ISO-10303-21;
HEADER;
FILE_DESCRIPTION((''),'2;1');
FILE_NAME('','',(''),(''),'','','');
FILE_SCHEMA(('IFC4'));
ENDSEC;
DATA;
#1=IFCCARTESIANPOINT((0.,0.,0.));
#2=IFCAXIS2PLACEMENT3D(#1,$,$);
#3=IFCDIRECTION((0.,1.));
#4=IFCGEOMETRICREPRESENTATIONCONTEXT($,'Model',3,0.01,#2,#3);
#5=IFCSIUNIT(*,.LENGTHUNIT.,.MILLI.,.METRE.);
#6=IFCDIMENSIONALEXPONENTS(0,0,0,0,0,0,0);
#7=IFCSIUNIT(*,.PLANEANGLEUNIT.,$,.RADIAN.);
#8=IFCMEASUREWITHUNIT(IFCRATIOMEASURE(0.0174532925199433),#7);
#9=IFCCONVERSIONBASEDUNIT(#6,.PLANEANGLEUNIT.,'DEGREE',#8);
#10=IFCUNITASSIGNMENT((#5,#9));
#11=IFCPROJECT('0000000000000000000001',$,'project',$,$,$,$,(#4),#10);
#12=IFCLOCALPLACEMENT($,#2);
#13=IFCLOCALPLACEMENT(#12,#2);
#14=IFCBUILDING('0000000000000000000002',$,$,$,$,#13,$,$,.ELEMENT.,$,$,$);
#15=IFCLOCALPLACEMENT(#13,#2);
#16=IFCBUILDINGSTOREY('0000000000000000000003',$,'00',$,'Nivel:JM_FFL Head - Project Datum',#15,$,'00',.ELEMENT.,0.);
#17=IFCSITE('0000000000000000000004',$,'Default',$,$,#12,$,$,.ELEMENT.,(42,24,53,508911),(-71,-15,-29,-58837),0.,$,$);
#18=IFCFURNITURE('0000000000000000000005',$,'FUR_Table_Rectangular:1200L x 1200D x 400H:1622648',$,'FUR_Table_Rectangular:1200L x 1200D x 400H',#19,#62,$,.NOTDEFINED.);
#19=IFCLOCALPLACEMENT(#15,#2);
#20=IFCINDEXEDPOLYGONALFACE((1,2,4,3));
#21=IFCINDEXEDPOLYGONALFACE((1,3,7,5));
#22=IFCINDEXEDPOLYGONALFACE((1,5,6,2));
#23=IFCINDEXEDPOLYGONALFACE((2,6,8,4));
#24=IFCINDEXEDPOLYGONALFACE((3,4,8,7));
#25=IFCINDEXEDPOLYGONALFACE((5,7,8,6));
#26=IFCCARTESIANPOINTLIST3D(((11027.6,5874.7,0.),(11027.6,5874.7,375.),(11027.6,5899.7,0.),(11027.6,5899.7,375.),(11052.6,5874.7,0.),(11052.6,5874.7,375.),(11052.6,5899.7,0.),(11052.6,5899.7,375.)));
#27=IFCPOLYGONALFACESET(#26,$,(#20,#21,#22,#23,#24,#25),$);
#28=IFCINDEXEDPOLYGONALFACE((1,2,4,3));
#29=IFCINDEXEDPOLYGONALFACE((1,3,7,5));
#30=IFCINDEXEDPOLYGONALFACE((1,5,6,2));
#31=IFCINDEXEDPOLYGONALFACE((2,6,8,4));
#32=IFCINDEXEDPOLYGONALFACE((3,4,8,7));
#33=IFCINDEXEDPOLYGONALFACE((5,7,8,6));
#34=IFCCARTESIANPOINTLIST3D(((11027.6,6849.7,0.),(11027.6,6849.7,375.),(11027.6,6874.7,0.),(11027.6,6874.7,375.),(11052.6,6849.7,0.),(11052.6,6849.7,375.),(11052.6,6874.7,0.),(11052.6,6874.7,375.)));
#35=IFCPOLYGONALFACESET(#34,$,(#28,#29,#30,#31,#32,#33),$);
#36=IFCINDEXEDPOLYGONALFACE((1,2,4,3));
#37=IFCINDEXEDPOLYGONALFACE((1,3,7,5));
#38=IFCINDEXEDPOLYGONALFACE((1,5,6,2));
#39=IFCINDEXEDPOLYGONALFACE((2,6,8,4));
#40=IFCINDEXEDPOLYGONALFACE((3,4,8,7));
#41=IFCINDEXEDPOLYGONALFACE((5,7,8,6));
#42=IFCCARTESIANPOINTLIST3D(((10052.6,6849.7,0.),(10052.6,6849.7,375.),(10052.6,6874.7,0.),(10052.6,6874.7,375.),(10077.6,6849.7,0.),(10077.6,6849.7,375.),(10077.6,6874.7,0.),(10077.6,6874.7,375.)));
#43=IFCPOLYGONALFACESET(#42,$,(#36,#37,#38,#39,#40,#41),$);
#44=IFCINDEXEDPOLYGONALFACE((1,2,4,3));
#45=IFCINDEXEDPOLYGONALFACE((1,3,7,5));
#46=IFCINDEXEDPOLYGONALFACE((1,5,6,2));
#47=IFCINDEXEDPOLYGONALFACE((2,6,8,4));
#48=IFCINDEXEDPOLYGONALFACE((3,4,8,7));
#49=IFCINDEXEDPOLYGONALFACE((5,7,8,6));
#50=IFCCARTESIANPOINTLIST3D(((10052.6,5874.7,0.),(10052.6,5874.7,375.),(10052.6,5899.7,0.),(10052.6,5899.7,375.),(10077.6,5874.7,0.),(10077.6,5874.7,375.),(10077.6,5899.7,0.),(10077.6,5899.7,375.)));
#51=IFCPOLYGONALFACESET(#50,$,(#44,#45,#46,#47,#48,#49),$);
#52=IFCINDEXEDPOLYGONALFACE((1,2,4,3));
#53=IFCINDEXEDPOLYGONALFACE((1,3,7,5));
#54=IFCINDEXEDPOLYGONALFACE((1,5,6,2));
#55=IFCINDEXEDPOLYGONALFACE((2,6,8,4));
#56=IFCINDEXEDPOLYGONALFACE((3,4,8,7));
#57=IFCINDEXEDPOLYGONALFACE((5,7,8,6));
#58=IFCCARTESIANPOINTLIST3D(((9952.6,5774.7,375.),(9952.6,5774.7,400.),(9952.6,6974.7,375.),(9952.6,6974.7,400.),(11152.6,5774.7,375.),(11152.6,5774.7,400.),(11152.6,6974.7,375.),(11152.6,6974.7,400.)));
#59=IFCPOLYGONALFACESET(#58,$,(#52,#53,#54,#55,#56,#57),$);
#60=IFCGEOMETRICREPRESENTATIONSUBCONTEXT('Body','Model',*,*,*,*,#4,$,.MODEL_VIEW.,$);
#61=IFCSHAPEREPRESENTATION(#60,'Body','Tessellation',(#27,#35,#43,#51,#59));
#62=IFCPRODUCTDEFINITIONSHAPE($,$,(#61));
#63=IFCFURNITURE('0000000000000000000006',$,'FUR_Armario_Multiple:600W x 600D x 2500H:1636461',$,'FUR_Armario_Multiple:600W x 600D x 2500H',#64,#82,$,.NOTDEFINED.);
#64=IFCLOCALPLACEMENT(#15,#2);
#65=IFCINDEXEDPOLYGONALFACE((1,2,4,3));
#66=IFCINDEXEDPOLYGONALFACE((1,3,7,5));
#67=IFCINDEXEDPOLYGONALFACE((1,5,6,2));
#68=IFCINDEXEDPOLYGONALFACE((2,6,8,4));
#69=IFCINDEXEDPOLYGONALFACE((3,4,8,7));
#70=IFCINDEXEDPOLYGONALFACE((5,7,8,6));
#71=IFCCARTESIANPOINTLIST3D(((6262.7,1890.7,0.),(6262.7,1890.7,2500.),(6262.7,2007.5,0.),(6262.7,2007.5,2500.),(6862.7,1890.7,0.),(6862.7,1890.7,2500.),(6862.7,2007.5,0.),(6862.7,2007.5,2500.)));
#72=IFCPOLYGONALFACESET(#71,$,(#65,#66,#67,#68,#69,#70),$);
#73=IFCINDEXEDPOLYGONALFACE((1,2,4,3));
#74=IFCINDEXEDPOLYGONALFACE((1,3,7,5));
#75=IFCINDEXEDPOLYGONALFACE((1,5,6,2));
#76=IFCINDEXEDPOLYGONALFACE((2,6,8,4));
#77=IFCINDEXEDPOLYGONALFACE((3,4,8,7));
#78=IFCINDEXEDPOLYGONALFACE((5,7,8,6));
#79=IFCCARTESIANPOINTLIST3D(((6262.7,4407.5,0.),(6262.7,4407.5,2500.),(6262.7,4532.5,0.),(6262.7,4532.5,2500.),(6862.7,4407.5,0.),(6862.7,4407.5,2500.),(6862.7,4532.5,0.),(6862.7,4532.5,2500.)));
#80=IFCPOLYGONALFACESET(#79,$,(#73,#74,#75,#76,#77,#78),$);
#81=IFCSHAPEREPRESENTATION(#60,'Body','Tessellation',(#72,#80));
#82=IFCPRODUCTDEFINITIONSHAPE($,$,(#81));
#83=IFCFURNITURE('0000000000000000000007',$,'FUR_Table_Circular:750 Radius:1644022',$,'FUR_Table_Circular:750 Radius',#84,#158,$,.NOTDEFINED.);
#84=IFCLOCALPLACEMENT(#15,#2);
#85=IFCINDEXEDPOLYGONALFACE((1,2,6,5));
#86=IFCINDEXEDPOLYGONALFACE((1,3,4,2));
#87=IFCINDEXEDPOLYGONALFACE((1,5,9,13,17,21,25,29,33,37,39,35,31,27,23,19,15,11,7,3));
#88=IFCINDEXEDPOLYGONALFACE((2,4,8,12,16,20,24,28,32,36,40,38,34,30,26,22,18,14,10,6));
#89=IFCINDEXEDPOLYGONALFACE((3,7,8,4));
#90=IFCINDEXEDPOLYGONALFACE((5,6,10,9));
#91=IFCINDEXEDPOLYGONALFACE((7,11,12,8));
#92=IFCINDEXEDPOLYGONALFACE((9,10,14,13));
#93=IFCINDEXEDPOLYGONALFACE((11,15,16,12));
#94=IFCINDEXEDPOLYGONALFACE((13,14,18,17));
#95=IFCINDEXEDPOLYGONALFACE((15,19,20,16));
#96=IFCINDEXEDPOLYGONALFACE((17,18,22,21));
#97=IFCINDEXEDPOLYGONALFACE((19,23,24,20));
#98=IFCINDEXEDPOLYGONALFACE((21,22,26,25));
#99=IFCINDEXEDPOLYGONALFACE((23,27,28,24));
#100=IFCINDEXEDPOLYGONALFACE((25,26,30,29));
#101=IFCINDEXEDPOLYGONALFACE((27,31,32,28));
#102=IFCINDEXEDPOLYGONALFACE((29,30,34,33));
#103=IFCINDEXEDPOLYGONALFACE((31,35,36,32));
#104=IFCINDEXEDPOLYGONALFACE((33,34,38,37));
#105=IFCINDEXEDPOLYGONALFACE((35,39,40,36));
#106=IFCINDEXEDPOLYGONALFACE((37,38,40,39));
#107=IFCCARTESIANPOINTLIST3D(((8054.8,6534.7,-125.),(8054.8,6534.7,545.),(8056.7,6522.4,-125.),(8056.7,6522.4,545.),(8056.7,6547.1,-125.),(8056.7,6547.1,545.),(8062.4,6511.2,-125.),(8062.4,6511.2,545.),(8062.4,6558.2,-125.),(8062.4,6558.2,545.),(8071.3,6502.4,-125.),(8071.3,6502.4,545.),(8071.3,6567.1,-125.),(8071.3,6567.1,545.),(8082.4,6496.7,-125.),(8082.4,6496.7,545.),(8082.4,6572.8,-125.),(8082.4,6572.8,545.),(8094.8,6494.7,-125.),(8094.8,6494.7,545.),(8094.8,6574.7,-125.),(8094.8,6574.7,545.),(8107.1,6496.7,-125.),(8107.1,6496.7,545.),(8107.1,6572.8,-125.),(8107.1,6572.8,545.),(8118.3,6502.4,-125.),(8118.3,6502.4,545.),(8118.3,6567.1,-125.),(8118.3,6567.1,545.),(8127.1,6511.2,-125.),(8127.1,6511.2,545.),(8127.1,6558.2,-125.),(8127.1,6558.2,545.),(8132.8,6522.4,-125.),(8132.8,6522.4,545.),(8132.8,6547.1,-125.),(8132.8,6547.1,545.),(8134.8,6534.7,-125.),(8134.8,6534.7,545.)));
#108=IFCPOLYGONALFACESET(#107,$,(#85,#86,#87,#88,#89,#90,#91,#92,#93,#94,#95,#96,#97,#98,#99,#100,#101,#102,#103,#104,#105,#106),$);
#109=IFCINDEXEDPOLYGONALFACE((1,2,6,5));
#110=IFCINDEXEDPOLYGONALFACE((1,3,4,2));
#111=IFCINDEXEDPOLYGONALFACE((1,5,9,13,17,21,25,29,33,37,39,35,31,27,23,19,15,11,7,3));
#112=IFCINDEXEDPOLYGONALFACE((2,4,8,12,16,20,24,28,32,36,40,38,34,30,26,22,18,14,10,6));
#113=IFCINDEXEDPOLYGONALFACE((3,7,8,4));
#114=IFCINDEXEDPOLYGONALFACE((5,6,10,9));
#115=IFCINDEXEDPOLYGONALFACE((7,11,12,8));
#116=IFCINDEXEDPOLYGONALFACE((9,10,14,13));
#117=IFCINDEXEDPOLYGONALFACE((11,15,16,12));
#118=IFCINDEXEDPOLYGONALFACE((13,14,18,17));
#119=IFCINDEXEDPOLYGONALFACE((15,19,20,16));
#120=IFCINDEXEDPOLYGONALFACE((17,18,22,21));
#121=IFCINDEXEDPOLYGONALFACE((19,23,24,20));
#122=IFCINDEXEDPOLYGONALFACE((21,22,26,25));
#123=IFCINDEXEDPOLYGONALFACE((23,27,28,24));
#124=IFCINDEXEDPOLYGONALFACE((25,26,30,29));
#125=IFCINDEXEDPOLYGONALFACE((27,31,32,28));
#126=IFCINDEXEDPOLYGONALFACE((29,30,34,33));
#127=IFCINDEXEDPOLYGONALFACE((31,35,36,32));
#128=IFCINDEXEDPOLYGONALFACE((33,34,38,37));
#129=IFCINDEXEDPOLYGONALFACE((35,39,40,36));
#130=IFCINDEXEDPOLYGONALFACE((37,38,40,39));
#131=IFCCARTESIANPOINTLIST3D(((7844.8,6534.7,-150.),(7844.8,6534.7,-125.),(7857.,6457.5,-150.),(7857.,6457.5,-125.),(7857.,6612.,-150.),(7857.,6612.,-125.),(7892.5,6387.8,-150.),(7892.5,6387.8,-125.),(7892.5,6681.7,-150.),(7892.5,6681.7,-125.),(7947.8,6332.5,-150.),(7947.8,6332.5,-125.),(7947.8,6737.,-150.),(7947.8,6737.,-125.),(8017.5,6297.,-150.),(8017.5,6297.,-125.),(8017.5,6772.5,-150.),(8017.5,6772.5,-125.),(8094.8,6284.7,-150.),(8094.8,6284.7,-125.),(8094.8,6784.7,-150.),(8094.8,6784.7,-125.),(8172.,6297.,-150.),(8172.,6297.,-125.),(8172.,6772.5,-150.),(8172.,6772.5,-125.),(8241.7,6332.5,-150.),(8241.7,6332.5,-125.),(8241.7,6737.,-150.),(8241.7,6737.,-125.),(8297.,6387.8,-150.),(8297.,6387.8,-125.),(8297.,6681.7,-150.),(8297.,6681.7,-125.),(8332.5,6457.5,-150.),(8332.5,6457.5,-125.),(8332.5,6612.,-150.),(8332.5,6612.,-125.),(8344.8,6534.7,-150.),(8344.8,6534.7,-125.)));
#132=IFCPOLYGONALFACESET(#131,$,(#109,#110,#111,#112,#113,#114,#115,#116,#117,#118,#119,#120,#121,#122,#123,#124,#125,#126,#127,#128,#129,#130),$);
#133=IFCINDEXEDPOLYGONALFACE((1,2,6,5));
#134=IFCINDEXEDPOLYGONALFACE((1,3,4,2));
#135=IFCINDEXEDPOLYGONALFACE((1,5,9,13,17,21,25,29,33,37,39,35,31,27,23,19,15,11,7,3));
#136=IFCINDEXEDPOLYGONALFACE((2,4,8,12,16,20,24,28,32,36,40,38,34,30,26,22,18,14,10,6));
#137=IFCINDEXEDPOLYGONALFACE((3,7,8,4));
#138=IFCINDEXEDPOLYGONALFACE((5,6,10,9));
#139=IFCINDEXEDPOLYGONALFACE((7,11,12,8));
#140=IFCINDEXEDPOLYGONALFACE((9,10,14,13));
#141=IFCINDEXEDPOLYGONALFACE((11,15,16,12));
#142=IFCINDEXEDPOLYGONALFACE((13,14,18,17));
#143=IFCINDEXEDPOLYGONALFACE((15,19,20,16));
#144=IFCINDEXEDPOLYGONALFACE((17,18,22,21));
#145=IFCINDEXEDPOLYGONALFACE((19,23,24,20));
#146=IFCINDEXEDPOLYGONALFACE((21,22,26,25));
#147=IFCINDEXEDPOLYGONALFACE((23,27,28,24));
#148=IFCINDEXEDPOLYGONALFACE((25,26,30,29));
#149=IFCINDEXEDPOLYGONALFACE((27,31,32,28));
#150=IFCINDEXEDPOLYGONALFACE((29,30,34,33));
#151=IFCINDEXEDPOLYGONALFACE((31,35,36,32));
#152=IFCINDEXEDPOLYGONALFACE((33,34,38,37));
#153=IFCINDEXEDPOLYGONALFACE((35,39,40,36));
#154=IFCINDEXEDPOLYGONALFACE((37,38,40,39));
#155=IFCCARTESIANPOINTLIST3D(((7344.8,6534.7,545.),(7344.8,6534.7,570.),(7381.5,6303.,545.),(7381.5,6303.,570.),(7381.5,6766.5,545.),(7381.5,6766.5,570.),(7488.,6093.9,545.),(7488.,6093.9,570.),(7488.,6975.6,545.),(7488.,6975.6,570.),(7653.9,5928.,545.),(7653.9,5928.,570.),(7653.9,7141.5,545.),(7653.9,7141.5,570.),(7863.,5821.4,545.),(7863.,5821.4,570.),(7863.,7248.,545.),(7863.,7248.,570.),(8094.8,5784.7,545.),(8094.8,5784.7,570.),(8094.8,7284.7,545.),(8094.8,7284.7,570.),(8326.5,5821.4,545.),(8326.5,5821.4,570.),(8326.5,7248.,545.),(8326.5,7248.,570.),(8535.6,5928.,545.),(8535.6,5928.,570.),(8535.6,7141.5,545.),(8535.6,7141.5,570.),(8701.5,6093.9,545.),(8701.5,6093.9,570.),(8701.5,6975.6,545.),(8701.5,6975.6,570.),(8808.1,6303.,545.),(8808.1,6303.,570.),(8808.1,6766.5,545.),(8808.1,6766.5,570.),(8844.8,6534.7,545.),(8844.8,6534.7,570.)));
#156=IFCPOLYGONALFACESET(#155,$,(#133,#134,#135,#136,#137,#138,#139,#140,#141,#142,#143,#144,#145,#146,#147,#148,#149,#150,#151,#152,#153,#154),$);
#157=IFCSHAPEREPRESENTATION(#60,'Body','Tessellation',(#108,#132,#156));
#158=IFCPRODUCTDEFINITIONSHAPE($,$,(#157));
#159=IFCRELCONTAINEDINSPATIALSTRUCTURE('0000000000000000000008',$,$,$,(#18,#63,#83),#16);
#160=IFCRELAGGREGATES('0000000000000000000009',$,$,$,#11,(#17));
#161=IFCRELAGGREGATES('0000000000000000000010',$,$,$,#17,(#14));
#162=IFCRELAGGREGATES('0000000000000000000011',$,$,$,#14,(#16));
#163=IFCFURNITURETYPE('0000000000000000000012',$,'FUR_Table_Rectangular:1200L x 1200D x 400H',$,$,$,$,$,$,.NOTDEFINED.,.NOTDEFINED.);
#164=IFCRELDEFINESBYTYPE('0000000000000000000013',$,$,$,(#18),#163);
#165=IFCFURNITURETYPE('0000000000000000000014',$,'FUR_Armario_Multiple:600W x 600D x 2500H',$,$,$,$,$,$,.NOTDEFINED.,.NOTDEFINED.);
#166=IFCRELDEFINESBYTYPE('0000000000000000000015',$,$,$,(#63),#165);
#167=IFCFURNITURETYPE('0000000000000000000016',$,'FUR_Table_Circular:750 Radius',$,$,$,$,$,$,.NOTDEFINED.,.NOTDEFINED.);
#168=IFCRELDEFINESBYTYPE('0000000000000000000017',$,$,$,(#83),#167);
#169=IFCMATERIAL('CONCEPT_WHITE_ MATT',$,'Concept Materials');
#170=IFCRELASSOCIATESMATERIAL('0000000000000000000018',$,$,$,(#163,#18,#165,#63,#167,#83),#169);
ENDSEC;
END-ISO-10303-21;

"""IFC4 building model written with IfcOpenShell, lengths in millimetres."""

from ifc_helpers import new_model, entity, si_unit, converted_unit, direction, frame, origin, place, context, subcontext, project, spatial, indexed_curve, outline, extrude, source, transform, mapped, material, type_object, type_shapes, element, save


model = new_model("IFC4")

# Units and contexts
model_context = context("Model", 3, precision=0.01, world=origin(), true_north=direction((0.0, 1.0)))
body_context = subcontext(model_context, "Body", "Model", "MODEL_VIEW")
ifc_project = project(units=[si_unit("LENGTHUNIT", "METRE", prefix="MILLI"), converted_unit("PLANEANGLEUNIT", "DEGREE", entity("IfcRatioMeasure", 0.0174532925199433), si_unit("PLANEANGLEUNIT", "RADIAN"), dimensions=[0, 0, 0, 0, 0, 0, 0])], contexts=[model_context])

# Site, building, storey
site_placement = place(None, origin())
site = spatial("IfcSite", under=ifc_project, at=site_placement, Name="Default", CompositionType="ELEMENT", RefLatitude=(42, 24, 53, 508911), RefLongitude=(-71, -15, -29, -58837), RefElevation=0.0)
building_placement = place(site_placement, origin())
building = spatial("IfcBuilding", under=site, at=building_placement, CompositionType="ELEMENT")
storey_placement = place(building_placement, origin())
storey = spatial("IfcBuildingStorey", under=building, at=storey_placement, Name="00", ObjectType="Nivel:JM_FFL Head - Project Datum", LongName="00", CompositionType="ELEMENT", Elevation=0.0)

# Shared definitions
ifc_material_1 = material(Name="CONCEPT_WHITE_ MATT", Category="Concept Materials")

# Furniture
furniture_type_1 = type_object("IfcFurnitureType", Name="FUR_Table_Rectangular:1200L x 1200D x 400H", AssemblyPlace="NOTDEFINED", PredefinedType="NOTDEFINED", material=ifc_material_1)
shared_shape_1 = source(origin(), body_context, "Body", "SweptSolid", [
    extrude(outline(indexed_curve([(-12.5, -12.5), (12.5, -12.5), (12.5, 12.5), (-12.5, 12.5), (-12.5, -12.5)], self_intersect=False)), frame((87.5, 687.5, 0.0), z_axis=(0.0, 0.0, 1.0), x_axis=(-1.0, 0.0, 0.0)), (0.0, 0.0, 1.0), 375.0),
    extrude(outline(indexed_curve([(-12.5, -12.5), (12.5, -12.5), (12.5, 12.5), (-12.5, 12.5), (-12.5, -12.5)], self_intersect=False)), frame((-887.5, 687.5, 0.0), z_axis=(0.0, 0.0, 1.0), x_axis=(-1.0, 0.0, 0.0)), (0.0, 0.0, 1.0), 375.0),
    extrude(outline(indexed_curve([(-12.5, -12.5), (12.5, -12.5), (12.5, 12.5), (-12.5, 12.5), (-12.5, -12.5)], self_intersect=False)), frame((-887.5, -287.5, 0.0), z_axis=(0.0, 0.0, 1.0), x_axis=(-1.0, 0.0, 0.0)), (0.0, 0.0, 1.0), 375.0),
    extrude(outline(indexed_curve([(-12.5, -12.5), (12.5, -12.5), (12.5, 12.5), (-12.5, 12.5), (-12.5, -12.5)], self_intersect=False)), frame((87.5, -287.5, 0.0), z_axis=(0.0, 0.0, 1.0), x_axis=(-1.0, 0.0, 0.0)), (0.0, 0.0, 1.0), 375.0),
    extrude(outline(indexed_curve([(-600.0, -600.0), (600.0, -600.0), (600.0, 600.0), (-600.0, 600.0), (-600.0, -600.0)], self_intersect=False)), frame((-400.0, 200.0, 375.0), z_axis=(0.0, 0.0, 1.0), x_axis=(-1.0, 0.0, 0.0)), (0.0, 0.0, 1.0), 25.0),
])
type_shapes(furniture_type_1, [shared_shape_1])
furniture_1_placement = place(storey_placement, frame((10352.6, 5974.7, 0.0), z_axis=(0.0, 0.0, 1.0), x_axis=(0.0, -1.0, 0.0)))
element("IfcFurniture", 1, at=furniture_1_placement, inside=storey, type_object=furniture_type_1, material=ifc_material_1, Name="FUR_Table_Rectangular:1200L x 1200D x 400H:1622648", ObjectType="FUR_Table_Rectangular:1200L x 1200D x 400H", PredefinedType="NOTDEFINED", context=body_context, shape_type="MappedRepresentation", body=[
    mapped(shared_shape_1, transform((0.0, 0.0, 0.0), scale=1.0)),
])
furniture_type_2 = type_object("IfcFurnitureType", Name="FUR_Armario_Multiple:600W x 600D x 2500H", AssemblyPlace="NOTDEFINED", PredefinedType="NOTDEFINED", material=ifc_material_1)
shared_shape_2 = source(origin(), body_context, "Body", "SweptSolid", [
    extrude(outline(indexed_curve([(-300.0, -58.4), (300.0, -58.4), (300.0, 58.4), (-300.0, 58.4), (-300.0, -58.4)], self_intersect=False)), frame((2458.4, -300.0, 0.0), z_axis=(0.0, 0.0, 1.0), x_axis=(0.0, -1.0, 0.0)), (0.0, 0.0, 1.0), 2500.0),
    extrude(outline(indexed_curve([(-62.5, -300.0), (62.5, -300.0), (62.5, 300.0), (-62.5, 300.0), (-62.5, -300.0)], self_intersect=False)), frame((-62.5, -300.0, 0.0), z_axis=(0.0, 0.0, 1.0), x_axis=(-1.0, 0.0, 0.0)), (0.0, 0.0, 1.0), 2500.0),
])
type_shapes(furniture_type_2, [shared_shape_2])
furniture_2_placement = place(storey_placement, frame((6862.7, 4407.5, 0.0), z_axis=(0.0, 0.0, 1.0), x_axis=(0.0, -1.0, 0.0)))
element("IfcFurniture", 2, at=furniture_2_placement, inside=storey, type_object=furniture_type_2, material=ifc_material_1, Name="FUR_Armario_Multiple:600W x 600D x 2500H:1636461", ObjectType="FUR_Armario_Multiple:600W x 600D x 2500H", PredefinedType="NOTDEFINED", context=body_context, shape_type="MappedRepresentation", body=[
    mapped(shared_shape_2, transform((0.0, 0.0, 0.0), scale=1.0)),
])
furniture_type_3 = type_object("IfcFurnitureType", Name="FUR_Table_Circular:750 Radius", AssemblyPlace="NOTDEFINED", PredefinedType="NOTDEFINED", material=ifc_material_1)
shared_shape_3 = source(origin(), body_context, "Body", "SweptSolid", [
    extrude(outline(indexed_curve([(40.0, 0.0), (38.0, 12.4), (32.4, 23.5), (23.5, 32.4), (12.4, 38.0), (0.0, 40.0), (-12.4, 38.0), (-23.5, 32.4), (-32.4, 23.5), (-38.0, 12.4), (-40.0, 0.0), (-38.0, -12.4), (-32.4, -23.5), (-23.5, -32.4), (-12.4, -38.0), (0.0, -40.0), (12.4, -38.0), (23.5, -32.4), (32.4, -23.5), (38.0, -12.4), (40.0, 0.0)], self_intersect=False)), frame((0.0, 0.0, 25.0)), (0.0, 0.0, 1.0), 670.0),
    extrude(outline(indexed_curve([(250.0, 0.0), (237.8, 77.3), (202.3, 146.9), (146.9, 202.3), (77.3, 237.8), (0.0, 250.0), (-77.3, 237.8), (-146.9, 202.3), (-202.3, 146.9), (-237.8, 77.3), (-250.0, 0.0), (-237.8, -77.3), (-202.3, -146.9), (-146.9, -202.3), (-77.3, -237.8), (0.0, -250.0), (77.3, -237.8), (146.9, -202.3), (202.3, -146.9), (237.8, -77.3), (250.0, 0.0)], self_intersect=False)), origin(), (0.0, 0.0, 1.0), 25.0),
    extrude(outline(indexed_curve([(750.0, 0.0), (713.3, 231.8), (606.8, 440.8), (440.8, 606.8), (231.8, 713.3), (0.0, 750.0), (-231.8, 713.3), (-440.8, 606.8), (-606.8, 440.8), (-713.3, 231.8), (-750.0, 0.0), (-713.3, -231.8), (-606.8, -440.8), (-440.8, -606.8), (-231.8, -713.3), (0.0, -750.0), (231.8, -713.3), (440.8, -606.8), (606.8, -440.8), (713.3, -231.8), (750.0, 0.0)], self_intersect=False)), frame((0.0, 0.0, 695.0)), (0.0, 0.0, 1.0), 25.0),
])
type_shapes(furniture_type_3, [shared_shape_3])
furniture_3_placement = place(storey_placement, frame((8094.8, 6534.7, -150.0)))
element("IfcFurniture", 3, at=furniture_3_placement, inside=storey, type_object=furniture_type_3, material=ifc_material_1, Name="FUR_Table_Circular:750 Radius:1644022", ObjectType="FUR_Table_Circular:750 Radius", PredefinedType="NOTDEFINED", context=body_context, shape_type="MappedRepresentation", body=[
    mapped(shared_shape_3, transform((0.0, 0.0, 0.0), scale=1.0)),
])

save(model, "model.ifc")
